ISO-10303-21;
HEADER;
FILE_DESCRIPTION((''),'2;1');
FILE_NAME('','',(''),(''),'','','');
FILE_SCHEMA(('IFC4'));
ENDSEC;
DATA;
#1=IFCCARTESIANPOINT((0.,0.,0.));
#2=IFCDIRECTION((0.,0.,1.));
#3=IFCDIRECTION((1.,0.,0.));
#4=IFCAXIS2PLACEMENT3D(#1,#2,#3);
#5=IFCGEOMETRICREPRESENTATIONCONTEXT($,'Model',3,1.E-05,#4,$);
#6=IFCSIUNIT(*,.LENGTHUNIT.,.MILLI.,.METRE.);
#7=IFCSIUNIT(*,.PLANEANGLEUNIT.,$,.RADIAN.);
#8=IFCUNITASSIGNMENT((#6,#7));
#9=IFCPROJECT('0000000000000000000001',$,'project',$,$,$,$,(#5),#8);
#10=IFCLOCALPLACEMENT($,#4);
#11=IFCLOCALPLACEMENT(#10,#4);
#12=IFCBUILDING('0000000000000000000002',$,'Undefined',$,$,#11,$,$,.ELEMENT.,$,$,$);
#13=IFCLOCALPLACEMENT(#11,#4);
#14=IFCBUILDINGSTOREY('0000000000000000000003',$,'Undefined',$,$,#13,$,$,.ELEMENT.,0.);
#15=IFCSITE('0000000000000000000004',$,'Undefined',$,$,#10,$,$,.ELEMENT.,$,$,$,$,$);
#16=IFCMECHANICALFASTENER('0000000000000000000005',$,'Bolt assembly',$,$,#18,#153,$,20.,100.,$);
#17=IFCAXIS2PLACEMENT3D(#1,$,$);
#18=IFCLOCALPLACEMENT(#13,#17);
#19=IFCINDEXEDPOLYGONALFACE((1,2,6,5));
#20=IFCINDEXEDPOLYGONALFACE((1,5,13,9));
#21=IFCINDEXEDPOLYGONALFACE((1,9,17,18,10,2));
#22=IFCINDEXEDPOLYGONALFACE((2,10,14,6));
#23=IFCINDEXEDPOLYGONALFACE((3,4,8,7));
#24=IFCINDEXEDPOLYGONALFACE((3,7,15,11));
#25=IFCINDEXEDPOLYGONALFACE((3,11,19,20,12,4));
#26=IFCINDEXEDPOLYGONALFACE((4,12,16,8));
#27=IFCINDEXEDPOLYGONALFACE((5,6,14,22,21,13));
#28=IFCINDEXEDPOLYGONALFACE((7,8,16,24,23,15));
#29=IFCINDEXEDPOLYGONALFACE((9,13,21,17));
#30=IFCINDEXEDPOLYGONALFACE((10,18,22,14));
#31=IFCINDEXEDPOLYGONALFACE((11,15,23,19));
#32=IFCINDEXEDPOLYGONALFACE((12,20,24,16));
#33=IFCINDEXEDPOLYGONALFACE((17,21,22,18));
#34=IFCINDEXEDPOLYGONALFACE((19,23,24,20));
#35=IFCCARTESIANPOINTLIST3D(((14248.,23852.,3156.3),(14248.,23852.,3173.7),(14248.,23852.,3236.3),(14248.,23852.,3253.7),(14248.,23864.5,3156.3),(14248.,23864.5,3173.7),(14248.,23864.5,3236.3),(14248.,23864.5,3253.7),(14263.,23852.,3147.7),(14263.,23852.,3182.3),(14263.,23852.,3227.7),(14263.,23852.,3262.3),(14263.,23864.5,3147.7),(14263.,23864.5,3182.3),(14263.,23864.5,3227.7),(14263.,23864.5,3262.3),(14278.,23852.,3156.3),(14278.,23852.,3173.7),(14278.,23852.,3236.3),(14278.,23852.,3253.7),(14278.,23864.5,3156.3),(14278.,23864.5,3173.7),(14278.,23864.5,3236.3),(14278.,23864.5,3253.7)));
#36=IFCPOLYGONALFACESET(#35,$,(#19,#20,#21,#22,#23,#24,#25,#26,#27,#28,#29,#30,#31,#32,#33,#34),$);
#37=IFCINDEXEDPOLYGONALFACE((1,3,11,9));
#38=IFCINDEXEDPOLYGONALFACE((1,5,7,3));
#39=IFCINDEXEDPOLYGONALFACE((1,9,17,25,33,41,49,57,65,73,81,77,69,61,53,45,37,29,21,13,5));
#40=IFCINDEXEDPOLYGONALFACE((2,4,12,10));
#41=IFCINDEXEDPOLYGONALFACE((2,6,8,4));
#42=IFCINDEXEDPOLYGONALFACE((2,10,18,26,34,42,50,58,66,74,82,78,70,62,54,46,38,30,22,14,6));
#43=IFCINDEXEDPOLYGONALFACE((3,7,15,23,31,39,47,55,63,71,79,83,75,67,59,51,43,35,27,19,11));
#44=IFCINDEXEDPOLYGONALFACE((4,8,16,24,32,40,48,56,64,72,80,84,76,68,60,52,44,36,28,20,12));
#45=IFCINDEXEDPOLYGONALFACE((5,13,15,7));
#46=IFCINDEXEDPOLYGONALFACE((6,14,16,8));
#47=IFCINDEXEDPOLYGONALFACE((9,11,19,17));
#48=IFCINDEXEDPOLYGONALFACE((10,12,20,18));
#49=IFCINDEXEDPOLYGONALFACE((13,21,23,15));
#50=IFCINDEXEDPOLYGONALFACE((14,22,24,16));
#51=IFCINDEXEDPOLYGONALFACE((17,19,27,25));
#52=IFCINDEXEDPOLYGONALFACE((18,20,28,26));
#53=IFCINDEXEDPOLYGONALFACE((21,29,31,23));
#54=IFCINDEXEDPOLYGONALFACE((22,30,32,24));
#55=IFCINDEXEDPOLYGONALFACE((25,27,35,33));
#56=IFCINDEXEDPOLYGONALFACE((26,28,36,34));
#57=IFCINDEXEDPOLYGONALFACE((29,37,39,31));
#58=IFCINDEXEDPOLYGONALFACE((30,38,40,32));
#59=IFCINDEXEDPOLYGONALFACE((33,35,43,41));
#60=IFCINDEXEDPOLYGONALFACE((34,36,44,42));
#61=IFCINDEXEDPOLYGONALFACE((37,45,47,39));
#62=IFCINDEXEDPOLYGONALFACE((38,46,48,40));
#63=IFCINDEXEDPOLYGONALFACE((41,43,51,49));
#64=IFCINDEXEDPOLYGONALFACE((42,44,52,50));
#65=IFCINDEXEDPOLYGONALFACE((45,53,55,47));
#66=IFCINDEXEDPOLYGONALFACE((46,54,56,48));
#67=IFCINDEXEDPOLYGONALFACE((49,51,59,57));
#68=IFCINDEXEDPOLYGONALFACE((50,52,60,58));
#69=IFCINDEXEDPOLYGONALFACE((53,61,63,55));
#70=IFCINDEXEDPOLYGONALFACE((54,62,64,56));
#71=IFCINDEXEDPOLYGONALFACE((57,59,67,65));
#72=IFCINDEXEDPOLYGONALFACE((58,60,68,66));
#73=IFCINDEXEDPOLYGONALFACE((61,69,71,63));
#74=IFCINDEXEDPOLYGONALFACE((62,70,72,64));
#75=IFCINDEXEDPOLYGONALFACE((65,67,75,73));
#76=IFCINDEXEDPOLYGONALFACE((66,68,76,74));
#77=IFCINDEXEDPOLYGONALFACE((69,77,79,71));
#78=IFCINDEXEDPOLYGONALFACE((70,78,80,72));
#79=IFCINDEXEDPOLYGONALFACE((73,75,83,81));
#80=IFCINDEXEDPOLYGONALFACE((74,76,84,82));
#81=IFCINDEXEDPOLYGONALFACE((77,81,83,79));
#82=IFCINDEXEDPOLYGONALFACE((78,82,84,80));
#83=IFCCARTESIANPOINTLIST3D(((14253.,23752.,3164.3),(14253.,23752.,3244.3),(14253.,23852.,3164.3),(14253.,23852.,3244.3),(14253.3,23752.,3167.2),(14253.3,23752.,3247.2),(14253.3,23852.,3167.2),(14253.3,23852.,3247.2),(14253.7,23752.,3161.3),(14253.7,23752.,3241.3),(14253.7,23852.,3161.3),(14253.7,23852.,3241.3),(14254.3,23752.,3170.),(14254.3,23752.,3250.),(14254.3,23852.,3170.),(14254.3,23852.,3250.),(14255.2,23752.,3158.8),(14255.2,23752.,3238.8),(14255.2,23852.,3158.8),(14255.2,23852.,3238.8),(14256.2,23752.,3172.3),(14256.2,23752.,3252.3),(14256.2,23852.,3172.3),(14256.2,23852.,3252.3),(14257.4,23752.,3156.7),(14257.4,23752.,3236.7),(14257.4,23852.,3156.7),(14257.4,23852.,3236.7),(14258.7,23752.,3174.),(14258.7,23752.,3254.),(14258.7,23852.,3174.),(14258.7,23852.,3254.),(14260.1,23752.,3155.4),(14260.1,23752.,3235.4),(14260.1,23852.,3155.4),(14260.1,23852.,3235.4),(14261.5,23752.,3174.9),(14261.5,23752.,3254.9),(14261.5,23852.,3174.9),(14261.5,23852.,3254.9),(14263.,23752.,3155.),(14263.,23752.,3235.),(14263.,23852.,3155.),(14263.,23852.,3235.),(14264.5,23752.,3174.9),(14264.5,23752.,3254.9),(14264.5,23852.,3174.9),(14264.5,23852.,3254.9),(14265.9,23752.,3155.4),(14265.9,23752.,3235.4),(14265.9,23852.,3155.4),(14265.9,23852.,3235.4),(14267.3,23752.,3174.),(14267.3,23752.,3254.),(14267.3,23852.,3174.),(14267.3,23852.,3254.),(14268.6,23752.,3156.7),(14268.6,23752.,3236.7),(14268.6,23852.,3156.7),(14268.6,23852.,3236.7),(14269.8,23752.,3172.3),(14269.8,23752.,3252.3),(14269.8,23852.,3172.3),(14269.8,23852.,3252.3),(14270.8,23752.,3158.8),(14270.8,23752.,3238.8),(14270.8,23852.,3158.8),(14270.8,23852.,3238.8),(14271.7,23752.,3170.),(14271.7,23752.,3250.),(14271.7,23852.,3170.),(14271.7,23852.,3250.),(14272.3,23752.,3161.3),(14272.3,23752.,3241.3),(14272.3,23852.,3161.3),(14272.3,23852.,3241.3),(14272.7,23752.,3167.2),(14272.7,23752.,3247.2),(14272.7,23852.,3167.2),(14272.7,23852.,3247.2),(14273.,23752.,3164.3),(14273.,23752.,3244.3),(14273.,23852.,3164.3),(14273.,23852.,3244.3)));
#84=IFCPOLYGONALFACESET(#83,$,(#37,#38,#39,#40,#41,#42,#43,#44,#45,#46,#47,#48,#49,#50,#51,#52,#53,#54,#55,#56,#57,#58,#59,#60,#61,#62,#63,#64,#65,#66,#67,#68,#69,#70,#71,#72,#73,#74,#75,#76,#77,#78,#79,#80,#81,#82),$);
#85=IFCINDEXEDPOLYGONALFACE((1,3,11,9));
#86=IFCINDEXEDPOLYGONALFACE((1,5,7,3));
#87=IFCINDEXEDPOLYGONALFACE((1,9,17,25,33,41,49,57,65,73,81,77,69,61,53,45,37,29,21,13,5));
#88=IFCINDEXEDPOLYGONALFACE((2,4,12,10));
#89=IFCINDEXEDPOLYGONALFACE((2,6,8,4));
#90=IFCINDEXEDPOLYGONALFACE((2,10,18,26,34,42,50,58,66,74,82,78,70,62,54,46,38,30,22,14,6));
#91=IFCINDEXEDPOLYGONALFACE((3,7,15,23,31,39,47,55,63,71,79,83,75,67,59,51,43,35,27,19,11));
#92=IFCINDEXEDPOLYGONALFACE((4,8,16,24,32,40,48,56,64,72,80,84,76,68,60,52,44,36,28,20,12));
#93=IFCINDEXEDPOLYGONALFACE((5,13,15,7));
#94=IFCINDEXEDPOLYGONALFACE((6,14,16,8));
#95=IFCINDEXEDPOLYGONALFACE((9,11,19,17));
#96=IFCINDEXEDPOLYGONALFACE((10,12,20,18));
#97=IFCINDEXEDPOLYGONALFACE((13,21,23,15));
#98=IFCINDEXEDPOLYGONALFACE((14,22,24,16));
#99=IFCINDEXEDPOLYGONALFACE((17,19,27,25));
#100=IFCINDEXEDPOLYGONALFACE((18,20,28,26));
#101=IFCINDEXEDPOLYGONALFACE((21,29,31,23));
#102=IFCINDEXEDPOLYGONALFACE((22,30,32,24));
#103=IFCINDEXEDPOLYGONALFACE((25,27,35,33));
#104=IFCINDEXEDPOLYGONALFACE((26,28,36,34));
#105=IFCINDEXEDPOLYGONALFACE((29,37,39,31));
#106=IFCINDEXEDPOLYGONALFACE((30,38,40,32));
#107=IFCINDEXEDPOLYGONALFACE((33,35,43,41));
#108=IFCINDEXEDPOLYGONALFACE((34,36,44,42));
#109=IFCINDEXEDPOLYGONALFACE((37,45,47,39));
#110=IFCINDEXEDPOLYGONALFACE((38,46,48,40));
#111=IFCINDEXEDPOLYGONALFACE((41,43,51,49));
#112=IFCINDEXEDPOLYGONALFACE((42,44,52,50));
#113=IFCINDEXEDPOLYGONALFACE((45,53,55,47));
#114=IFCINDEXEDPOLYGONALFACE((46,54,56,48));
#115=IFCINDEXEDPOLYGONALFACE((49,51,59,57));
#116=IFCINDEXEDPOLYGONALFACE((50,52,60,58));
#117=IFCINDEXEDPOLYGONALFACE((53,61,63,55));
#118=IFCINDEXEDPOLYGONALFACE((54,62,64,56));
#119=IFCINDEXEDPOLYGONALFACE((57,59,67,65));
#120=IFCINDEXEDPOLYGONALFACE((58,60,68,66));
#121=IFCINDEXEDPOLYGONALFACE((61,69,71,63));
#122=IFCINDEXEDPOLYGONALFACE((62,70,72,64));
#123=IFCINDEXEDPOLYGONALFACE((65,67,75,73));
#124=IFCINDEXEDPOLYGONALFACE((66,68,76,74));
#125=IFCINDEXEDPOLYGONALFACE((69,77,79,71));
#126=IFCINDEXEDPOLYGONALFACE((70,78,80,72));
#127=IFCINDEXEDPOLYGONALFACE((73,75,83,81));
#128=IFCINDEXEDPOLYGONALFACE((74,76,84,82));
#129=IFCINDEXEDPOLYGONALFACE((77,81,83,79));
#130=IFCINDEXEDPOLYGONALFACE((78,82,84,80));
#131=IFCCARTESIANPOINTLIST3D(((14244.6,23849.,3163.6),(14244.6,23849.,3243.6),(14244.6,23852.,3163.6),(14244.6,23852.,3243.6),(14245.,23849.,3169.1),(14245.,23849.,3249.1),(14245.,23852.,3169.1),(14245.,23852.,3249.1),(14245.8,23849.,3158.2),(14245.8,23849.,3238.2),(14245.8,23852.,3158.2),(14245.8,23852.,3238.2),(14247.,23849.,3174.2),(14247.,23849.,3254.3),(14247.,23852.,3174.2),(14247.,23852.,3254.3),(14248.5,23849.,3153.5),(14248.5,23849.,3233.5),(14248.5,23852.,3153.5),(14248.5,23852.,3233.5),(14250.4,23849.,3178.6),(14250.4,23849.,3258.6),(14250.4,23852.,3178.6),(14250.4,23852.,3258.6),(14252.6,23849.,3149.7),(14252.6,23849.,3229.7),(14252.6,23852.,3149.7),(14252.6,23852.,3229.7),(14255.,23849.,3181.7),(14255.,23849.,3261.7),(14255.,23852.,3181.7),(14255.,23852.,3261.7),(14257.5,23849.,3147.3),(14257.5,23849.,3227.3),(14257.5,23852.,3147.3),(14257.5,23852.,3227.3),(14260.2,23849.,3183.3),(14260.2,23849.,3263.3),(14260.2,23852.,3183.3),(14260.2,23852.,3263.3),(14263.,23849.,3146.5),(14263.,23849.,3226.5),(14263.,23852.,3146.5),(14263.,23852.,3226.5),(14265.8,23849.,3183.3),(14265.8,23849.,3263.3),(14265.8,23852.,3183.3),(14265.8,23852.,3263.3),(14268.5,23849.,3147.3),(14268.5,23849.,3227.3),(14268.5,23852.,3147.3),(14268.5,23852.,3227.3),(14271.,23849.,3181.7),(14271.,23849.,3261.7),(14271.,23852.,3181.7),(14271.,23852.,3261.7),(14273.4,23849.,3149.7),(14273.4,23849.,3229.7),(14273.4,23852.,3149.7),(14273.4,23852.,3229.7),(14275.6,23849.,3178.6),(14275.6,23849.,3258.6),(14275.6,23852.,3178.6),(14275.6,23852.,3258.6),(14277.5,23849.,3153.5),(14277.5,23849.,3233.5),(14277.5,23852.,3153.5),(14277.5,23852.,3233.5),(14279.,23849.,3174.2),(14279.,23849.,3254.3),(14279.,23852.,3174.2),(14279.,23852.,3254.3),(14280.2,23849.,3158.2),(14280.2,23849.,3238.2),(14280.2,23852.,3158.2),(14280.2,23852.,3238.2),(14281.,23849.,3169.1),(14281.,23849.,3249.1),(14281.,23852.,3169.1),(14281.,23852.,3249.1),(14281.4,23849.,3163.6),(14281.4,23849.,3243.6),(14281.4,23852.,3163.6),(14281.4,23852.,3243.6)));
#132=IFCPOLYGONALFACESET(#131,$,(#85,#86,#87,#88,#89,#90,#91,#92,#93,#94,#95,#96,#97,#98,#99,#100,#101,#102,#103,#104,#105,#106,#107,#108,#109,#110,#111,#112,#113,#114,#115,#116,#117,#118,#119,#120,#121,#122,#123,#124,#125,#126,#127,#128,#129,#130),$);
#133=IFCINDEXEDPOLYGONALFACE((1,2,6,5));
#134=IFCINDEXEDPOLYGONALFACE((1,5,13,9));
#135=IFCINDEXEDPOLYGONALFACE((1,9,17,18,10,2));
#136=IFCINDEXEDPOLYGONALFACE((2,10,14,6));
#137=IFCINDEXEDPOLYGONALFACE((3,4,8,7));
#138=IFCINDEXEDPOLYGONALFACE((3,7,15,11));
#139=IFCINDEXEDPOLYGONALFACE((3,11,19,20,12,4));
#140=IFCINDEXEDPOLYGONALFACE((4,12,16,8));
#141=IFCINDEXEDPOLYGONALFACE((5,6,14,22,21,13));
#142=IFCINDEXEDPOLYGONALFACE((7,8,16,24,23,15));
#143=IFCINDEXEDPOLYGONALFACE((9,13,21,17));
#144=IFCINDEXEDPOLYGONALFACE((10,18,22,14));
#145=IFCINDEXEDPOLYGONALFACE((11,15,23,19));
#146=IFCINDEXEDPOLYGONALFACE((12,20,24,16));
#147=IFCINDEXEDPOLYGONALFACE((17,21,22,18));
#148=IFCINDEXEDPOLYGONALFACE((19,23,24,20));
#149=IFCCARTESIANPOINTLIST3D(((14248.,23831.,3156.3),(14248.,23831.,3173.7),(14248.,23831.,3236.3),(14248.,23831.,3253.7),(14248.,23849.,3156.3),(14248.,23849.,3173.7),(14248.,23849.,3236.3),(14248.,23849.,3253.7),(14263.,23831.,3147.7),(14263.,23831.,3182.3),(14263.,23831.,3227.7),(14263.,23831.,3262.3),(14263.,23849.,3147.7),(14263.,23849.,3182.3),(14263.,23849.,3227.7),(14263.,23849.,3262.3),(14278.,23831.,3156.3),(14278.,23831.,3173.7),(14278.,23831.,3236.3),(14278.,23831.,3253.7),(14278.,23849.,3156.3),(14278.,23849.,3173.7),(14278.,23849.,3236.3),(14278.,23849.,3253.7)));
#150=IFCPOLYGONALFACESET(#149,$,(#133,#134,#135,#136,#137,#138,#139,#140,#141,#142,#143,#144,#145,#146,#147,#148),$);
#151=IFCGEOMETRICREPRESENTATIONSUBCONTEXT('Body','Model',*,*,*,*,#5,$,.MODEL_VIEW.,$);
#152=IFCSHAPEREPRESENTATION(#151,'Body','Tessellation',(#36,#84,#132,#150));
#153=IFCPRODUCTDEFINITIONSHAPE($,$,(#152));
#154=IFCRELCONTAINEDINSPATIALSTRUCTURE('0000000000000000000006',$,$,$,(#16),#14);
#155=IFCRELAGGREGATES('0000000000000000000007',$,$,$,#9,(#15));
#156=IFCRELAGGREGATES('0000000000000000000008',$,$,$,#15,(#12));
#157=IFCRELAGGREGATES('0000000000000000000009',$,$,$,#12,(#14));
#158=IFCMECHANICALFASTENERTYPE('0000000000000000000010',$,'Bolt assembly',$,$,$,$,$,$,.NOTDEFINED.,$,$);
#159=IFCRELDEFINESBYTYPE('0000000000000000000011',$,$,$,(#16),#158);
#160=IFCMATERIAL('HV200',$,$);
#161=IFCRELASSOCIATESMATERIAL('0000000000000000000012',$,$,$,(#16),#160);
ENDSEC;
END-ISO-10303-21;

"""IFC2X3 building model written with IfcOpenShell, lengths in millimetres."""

from ifc_helpers import new_model, si_unit, frame, origin_with_axes, origin_2d_with_axis, place, context, subcontext, project, spatial, polyline, circle, outline, extrude, source, transform, mapped, material, type_object, element, save


model = new_model("IFC2X3")

# Units and contexts
model_context = context("Model", 3, precision=1e-05, world=origin_with_axes())
body_context = subcontext(model_context, "Body", "Model", "MODEL_VIEW")
ifc_project = project(units=[si_unit("LENGTHUNIT", "METRE", prefix="MILLI"), si_unit("PLANEANGLEUNIT", "RADIAN")], contexts=[model_context])

# Site, building, storey
site_placement = place(None, origin_with_axes())
site = spatial("IfcSite", under=ifc_project, at=site_placement, Name="Undefined", CompositionType="ELEMENT")
building_placement = place(site_placement, origin_with_axes())
building = spatial("IfcBuilding", under=site, at=building_placement, Name="Undefined", CompositionType="ELEMENT")
storey_placement = place(building_placement, origin_with_axes())
storey = spatial("IfcBuildingStorey", under=building, at=storey_placement, Name="Undefined", CompositionType="ELEMENT", Elevation=0.0)

# Mechanical fastener
ifc_material_1 = material(Name="HV200")
mechanical_fastener_type = type_object("IfcMechanicalFastenerType", Name="Bolt assembly")
shared_shape_1 = source(origin_with_axes(), body_context, "Body", "SweptSolid", [
    extrude(outline(polyline([(17.3, 0.0), (8.7, 15.0), (-8.7, 15.0), (-17.3, 0.0), (-8.7, -15.0), (8.7, -15.0), (17.3, 0.0)])), frame((0.0, -12.5, 0.0), z_axis=(0.0, 1.0, 0.0), x_axis=(1.0, 0.0, 0.0)), (0.0, 0.0, 1.0), 12.5),
    extrude(circle(Radius=10.0, at=origin_2d_with_axis()), frame((0.0, 0.0, 0.0), z_axis=(0.0, 1.0, 0.0), x_axis=(1.0, 0.0, 0.0)), (0.0, 0.0, 1.0), 100.0),
    extrude(circle(Radius=18.5, at=origin_2d_with_axis()), frame((0.0, 0.0, 0.0), z_axis=(0.0, 1.0, 0.0), x_axis=(1.0, 0.0, 0.0)), (0.0, 0.0, 1.0), 3.0),
    extrude(outline(polyline([(17.3, 0.0), (8.7, 15.0), (-8.7, 15.0), (-17.3, 0.0), (-8.7, -15.0), (8.7, -15.0), (17.3, 0.0)])), frame((0.0, 3.0, 0.0), z_axis=(0.0, 1.0, 0.0), x_axis=(1.0, 0.0, 0.0)), (0.0, 0.0, 1.0), 18.0),
])
for number, where, z_axis, x_axis, name in (
    (1, (14263.0, 23852.0, 3245.0), (-1.0, 0.0, 0.0), (0.0, 0.0, -1.0), "Bolt assembly"),
):
    element("IfcMechanicalFastener", number, at=place(storey_placement, frame(where, z_axis=z_axis, x_axis=x_axis)), inside=storey, type_object=mechanical_fastener_type, material=ifc_material_1, Name=name, NominalDiameter=20.0, NominalLength=100.0, context=body_context, shape_type="MappedRepresentation", body=[
        mapped(shared_shape_1, transform((0.0, 0.0, 0.0))),
        mapped(shared_shape_1, transform((80.0, 0.0, 0.0))),
    ])

save(model, "model.ifc")
